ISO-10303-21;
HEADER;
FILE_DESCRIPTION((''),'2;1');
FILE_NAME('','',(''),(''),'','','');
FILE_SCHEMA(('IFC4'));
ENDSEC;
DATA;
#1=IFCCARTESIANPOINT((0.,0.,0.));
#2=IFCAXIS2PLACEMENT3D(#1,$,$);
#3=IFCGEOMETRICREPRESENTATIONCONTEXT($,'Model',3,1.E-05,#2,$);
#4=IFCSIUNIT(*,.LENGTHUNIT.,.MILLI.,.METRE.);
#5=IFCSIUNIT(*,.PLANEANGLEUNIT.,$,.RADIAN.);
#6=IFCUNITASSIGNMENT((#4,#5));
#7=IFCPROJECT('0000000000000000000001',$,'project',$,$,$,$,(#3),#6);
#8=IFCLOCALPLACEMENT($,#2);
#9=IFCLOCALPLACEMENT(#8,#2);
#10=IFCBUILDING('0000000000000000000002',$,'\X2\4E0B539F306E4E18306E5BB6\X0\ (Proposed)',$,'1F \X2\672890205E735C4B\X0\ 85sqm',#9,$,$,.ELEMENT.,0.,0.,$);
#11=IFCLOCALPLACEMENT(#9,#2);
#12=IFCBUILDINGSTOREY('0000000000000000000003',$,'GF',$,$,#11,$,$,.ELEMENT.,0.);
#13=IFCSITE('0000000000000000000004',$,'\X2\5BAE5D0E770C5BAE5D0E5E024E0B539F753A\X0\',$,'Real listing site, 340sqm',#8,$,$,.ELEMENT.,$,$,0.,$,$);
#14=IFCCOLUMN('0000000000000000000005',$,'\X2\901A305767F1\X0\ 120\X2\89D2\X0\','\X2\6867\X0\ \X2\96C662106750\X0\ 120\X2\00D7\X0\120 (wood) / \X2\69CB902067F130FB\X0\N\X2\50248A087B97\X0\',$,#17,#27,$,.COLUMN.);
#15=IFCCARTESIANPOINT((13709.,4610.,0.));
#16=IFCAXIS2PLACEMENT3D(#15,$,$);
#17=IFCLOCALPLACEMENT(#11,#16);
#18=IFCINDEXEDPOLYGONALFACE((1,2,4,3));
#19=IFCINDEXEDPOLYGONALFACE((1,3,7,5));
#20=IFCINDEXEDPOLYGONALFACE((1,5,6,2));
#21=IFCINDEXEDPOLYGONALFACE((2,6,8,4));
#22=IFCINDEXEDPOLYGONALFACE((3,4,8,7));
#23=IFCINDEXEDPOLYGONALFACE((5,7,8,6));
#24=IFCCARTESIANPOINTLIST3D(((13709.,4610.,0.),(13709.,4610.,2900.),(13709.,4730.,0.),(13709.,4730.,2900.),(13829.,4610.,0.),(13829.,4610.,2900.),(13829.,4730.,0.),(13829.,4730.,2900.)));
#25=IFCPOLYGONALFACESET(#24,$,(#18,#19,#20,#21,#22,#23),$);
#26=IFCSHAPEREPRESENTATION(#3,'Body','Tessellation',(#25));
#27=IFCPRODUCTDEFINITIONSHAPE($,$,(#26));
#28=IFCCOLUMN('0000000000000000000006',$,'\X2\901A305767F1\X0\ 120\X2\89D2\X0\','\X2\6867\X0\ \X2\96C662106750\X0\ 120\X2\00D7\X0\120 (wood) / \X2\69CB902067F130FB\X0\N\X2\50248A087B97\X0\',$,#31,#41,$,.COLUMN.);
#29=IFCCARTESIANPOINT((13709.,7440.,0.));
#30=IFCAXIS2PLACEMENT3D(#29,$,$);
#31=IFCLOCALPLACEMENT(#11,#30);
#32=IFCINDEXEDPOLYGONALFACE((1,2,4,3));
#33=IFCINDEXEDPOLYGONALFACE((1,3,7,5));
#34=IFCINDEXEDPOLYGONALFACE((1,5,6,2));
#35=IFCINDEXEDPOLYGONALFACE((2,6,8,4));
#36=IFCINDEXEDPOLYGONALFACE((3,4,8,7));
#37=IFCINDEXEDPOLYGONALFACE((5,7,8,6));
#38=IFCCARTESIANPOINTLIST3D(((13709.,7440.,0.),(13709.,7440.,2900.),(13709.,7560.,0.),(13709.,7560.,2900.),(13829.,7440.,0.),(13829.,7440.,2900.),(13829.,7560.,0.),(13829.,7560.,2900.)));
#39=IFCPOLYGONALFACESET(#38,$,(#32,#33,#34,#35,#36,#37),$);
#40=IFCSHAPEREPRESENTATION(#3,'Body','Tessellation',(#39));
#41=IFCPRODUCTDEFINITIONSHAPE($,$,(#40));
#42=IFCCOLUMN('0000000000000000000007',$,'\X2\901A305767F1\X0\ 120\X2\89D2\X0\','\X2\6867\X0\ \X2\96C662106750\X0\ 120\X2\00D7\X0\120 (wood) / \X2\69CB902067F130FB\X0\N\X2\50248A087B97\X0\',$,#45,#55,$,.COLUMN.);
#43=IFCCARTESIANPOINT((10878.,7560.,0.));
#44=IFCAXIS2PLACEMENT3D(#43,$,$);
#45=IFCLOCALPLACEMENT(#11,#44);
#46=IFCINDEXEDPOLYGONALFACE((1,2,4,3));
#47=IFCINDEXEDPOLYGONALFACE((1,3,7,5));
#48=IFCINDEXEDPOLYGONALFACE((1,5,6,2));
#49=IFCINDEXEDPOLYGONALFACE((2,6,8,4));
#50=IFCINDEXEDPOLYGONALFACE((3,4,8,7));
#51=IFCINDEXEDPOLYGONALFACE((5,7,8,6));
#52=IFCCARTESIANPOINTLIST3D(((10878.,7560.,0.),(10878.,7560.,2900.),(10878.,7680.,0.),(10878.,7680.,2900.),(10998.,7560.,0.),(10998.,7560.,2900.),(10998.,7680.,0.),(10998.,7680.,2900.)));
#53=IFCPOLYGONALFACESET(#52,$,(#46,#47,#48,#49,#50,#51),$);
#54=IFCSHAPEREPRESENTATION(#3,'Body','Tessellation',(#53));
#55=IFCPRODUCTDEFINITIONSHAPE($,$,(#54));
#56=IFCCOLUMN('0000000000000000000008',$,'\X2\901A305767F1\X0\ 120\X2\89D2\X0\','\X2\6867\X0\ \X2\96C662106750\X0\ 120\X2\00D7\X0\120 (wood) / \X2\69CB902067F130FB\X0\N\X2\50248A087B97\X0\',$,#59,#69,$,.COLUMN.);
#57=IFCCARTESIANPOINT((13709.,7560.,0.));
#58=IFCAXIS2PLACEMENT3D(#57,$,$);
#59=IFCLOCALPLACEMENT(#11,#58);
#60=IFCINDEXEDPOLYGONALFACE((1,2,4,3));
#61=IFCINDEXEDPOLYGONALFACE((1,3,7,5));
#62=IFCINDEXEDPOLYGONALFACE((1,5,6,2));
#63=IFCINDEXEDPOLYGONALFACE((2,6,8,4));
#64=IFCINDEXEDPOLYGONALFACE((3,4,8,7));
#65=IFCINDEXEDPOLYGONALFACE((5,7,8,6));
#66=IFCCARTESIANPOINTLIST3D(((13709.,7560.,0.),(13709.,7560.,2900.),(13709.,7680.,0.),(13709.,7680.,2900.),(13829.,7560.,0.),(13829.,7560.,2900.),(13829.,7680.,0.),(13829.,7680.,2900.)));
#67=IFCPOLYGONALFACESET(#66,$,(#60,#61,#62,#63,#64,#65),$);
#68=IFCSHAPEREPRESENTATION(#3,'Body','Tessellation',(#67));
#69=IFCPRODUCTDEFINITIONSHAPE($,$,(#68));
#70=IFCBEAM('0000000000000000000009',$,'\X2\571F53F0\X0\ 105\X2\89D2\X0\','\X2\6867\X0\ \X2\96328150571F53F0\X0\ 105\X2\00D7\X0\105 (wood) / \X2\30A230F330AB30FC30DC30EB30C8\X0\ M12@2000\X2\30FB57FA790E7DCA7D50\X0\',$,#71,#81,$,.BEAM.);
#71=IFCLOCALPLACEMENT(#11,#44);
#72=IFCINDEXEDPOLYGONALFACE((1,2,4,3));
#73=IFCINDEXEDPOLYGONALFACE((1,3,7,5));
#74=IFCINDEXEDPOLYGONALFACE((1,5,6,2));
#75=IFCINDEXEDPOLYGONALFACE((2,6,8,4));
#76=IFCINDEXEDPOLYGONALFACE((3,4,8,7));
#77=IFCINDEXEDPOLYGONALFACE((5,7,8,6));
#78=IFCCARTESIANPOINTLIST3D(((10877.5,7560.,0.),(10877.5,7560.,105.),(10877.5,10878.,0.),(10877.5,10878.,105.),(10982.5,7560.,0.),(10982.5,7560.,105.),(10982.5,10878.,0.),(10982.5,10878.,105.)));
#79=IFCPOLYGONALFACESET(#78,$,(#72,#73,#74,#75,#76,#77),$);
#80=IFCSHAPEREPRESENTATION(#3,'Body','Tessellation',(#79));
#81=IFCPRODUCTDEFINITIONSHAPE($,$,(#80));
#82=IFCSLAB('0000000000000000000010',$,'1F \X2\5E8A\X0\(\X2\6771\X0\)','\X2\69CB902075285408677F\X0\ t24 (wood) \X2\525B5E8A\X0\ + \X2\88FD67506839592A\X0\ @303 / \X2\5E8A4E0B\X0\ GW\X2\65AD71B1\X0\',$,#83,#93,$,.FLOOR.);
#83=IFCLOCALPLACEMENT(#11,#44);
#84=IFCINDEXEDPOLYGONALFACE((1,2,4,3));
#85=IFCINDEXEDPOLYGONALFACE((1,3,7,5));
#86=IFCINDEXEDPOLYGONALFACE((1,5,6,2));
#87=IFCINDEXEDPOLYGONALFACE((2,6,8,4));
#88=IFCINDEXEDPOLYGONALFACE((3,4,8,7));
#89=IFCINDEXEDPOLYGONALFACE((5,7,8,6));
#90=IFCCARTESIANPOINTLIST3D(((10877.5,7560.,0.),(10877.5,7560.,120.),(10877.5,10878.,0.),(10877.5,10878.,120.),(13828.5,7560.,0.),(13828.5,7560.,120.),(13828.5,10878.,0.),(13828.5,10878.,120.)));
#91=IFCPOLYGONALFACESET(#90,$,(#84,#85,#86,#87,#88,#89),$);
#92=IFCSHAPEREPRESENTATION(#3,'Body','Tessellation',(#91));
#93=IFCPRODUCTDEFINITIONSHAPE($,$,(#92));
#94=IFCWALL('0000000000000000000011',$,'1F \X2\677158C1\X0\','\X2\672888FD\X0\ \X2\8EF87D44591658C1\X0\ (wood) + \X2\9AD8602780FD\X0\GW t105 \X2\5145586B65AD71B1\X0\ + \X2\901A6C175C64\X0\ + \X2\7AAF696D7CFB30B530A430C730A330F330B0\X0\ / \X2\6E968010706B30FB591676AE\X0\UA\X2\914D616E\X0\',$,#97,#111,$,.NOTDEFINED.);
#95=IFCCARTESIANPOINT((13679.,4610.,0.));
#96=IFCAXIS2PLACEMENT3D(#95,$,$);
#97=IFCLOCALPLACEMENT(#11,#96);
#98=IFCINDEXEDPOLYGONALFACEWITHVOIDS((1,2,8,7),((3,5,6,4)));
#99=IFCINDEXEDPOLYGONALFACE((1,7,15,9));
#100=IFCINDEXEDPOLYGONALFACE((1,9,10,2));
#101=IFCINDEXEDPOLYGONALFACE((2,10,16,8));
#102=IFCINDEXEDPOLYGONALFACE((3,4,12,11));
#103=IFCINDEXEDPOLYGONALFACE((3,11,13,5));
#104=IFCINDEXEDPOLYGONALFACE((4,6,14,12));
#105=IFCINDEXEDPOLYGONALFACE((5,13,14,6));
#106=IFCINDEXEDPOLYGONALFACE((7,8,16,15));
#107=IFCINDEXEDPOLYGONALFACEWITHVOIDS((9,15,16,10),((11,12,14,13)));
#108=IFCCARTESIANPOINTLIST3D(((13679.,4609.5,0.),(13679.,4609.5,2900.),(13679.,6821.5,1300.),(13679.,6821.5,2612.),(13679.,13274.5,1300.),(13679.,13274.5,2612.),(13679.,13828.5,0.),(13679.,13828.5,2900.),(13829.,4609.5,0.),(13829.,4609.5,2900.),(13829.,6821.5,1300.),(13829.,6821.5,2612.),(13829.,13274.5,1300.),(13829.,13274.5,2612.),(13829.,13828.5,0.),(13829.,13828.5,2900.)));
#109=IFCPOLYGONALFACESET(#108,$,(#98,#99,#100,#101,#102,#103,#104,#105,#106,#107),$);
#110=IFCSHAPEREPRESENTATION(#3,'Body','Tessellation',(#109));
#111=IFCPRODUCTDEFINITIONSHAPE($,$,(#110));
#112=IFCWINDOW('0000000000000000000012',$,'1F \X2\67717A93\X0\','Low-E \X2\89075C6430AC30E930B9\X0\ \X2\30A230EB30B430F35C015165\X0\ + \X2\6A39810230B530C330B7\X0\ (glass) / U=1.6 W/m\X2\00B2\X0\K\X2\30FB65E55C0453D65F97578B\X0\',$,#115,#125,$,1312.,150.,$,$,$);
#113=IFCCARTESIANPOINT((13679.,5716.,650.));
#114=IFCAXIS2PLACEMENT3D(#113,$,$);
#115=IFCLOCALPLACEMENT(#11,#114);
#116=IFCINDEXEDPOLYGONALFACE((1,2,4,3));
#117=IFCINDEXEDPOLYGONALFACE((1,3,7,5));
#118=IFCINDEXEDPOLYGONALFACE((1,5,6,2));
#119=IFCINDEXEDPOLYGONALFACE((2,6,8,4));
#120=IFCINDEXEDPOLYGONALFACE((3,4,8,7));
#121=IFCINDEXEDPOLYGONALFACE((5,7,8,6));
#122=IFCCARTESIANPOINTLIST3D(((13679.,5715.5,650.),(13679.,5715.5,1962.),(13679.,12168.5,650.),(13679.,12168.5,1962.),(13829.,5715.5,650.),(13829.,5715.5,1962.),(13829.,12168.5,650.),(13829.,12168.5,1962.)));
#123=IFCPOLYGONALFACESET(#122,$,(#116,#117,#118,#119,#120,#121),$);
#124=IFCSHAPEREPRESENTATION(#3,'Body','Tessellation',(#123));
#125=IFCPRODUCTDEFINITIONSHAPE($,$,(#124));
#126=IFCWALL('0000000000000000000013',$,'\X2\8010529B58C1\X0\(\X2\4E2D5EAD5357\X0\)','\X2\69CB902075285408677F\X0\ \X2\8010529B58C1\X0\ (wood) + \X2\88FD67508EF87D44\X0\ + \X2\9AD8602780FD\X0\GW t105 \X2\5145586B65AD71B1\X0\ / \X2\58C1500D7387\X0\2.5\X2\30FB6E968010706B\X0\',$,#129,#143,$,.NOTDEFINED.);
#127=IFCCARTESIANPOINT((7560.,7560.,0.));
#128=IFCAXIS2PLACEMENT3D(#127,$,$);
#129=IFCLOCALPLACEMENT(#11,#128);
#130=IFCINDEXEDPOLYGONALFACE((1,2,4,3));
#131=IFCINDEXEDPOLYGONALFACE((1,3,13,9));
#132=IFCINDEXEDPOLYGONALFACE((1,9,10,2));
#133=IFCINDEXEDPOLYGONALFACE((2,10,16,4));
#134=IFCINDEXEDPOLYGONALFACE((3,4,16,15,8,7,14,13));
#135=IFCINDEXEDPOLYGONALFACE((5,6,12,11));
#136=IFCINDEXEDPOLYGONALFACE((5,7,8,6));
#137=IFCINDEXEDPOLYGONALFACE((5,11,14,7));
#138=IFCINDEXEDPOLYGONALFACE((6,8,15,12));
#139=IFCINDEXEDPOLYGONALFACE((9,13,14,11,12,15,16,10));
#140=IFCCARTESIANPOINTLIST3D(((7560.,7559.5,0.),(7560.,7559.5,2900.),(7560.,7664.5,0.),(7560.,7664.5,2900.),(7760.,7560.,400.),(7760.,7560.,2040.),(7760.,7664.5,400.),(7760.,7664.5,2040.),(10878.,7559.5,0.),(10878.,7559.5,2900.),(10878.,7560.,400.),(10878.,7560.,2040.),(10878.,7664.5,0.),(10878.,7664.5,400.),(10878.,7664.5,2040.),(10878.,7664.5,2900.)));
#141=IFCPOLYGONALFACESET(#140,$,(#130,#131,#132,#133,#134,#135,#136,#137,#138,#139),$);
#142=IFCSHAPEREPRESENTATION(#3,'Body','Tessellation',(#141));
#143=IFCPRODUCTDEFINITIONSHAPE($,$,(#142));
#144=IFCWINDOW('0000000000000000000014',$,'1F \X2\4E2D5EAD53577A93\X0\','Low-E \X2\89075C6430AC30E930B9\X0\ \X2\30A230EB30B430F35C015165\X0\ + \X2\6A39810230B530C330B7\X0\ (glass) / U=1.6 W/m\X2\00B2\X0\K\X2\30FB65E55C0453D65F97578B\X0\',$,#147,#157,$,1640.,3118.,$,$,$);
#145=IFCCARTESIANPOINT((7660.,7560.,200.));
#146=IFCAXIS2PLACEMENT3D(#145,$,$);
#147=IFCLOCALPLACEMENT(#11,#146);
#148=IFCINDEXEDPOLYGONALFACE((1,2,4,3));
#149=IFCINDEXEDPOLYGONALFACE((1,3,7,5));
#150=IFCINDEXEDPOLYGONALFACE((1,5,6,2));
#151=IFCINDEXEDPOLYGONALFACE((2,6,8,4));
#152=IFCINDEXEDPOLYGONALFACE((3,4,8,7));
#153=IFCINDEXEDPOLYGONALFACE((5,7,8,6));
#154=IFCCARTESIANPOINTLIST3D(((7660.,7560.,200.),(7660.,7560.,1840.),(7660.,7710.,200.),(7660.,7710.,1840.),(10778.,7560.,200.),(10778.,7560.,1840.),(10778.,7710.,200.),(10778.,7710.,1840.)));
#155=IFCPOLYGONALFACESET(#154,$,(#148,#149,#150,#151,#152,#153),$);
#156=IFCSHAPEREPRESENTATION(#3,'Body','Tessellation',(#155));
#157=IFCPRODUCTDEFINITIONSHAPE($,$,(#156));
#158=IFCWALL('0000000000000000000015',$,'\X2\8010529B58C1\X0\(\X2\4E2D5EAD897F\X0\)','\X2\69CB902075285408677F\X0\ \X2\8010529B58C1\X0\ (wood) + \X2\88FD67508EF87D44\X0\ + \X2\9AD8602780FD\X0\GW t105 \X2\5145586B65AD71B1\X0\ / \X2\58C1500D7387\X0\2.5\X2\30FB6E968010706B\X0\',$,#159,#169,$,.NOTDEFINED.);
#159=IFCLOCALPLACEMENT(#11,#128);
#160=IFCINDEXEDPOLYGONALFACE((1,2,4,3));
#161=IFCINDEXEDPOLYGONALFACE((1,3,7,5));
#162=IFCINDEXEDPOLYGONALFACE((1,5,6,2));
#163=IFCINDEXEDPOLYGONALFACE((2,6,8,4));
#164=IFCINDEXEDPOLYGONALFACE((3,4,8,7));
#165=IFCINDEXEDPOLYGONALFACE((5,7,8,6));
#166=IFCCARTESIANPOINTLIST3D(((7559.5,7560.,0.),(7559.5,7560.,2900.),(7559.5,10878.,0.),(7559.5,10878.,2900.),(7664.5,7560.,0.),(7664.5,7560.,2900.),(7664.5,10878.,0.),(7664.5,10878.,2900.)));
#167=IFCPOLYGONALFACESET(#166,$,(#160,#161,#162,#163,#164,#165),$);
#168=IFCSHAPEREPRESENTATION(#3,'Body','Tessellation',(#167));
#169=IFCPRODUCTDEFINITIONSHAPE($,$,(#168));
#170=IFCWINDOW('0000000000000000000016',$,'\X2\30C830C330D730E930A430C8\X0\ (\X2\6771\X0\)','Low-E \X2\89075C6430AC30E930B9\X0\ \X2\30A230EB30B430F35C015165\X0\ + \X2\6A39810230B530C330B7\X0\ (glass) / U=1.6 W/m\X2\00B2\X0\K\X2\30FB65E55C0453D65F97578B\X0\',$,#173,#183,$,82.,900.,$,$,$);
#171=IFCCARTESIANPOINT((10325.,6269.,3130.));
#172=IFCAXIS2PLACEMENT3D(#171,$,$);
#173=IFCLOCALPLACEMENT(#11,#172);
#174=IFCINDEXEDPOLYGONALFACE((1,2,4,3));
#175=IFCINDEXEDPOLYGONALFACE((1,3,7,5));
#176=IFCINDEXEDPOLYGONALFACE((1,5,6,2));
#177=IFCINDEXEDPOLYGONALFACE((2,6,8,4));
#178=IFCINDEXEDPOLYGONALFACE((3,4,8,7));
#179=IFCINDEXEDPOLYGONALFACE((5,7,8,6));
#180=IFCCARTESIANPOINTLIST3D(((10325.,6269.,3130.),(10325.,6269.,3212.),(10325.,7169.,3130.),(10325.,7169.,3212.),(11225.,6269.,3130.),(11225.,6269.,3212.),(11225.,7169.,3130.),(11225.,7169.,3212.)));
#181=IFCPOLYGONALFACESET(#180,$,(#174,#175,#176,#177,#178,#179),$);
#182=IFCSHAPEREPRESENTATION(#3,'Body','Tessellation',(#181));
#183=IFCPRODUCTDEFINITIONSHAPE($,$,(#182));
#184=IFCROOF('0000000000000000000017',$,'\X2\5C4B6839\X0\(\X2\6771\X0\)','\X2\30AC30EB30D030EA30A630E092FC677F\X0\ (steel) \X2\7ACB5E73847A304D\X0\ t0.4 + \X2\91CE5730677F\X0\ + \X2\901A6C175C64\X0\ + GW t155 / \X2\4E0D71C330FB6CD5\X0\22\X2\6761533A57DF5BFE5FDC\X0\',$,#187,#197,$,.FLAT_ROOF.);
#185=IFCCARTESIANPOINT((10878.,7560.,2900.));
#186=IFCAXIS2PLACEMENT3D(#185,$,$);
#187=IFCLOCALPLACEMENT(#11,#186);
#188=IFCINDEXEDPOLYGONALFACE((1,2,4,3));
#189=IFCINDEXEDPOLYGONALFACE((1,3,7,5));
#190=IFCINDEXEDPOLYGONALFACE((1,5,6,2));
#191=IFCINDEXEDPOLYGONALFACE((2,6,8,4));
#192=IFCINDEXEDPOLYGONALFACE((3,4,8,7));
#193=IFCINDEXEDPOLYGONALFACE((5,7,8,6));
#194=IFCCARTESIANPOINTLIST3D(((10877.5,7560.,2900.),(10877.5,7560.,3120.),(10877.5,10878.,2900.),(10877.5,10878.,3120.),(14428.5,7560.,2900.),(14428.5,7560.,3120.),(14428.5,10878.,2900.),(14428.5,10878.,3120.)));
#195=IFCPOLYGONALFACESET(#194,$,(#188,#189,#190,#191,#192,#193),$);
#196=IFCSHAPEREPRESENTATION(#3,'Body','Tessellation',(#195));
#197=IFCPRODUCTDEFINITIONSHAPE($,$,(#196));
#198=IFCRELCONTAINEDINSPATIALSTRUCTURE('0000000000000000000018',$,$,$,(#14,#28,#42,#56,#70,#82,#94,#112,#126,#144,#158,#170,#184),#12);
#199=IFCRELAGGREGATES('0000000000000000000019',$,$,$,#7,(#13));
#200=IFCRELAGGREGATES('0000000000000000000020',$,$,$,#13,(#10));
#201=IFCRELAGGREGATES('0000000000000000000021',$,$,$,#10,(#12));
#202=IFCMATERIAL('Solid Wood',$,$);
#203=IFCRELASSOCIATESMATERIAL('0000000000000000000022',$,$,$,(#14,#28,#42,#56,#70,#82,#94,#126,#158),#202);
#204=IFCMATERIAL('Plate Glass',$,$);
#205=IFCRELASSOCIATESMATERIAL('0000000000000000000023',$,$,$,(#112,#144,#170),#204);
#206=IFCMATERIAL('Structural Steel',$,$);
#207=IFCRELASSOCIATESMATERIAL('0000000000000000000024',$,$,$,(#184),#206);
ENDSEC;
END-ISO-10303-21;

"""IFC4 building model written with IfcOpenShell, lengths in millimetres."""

from ifc_helpers import new_model, si_unit, frame, frame_2d, origin, place, context, project, spatial, rectangle, extrude, material, element, fill, save


model = new_model("IFC4")

# Units and contexts
model_context = context("Model", 3, precision=1e-05, world=origin())
ifc_project = project(units=[si_unit("LENGTHUNIT", "METRE", prefix="MILLI"), si_unit("PLANEANGLEUNIT", "RADIAN")], contexts=[model_context])

# Site, building, storey
site_placement = place(None, origin())
site = spatial("IfcSite", under=ifc_project, at=site_placement, Name="宮崎県宮崎市下原町", ObjectType="Real listing site, 340sqm", CompositionType="ELEMENT", RefElevation=0.0)
building_placement = place(site_placement, origin())
building = spatial("IfcBuilding", under=site, at=building_placement, Name="下原の丘の家 (Proposed)", ObjectType="1F 木造平屋 85sqm", CompositionType="ELEMENT", ElevationOfRefHeight=0.0, ElevationOfTerrain=0.0)
storey_placement = place(building_placement, origin())
storey = spatial("IfcBuildingStorey", under=building, at=storey_placement, Name="GF", CompositionType="ELEMENT", Elevation=0.0)

# Columns
ifc_material_1 = material(Name="Solid Wood")
column_1_placement = place(storey_placement, frame((13709.0, 4610.0, 0.0)))
element("IfcColumn", 1, at=column_1_placement, inside=storey, material=ifc_material_1, Name="通し柱 120角", Description="桧 集成材 120×120 (wood) / 構造柱・N値計算", PredefinedType="COLUMN", context=model_context, shape_type="SweptSolid", body=[
    extrude(rectangle(XDim=120.0, YDim=120.0, at=frame_2d((60.0, 60.0))), frame((13709.0, 4610.0, 0.0)), (0.0, 0.0, 1.0), 2900.0),
])
column_2_placement = place(storey_placement, frame((13709.0, 7440.0, 0.0)))
element("IfcColumn", 2, at=column_2_placement, inside=storey, material=ifc_material_1, Name="通し柱 120角", Description="桧 集成材 120×120 (wood) / 構造柱・N値計算", PredefinedType="COLUMN", context=model_context, shape_type="SweptSolid", body=[
    extrude(rectangle(XDim=120.0, YDim=120.0, at=frame_2d((60.0, 60.0))), frame((13709.0, 7440.0, 0.0)), (0.0, 0.0, 1.0), 2900.0),
])
column_3_placement = place(storey_placement, frame((10878.0, 7560.0, 0.0)))
element("IfcColumn", 3, at=column_3_placement, inside=storey, material=ifc_material_1, Name="通し柱 120角", Description="桧 集成材 120×120 (wood) / 構造柱・N値計算", PredefinedType="COLUMN", context=model_context, shape_type="SweptSolid", body=[
    extrude(rectangle(XDim=120.0, YDim=120.0, at=frame_2d((60.0, 60.0))), frame((10878.0, 7560.0, 0.0)), (0.0, 0.0, 1.0), 2900.0),
])
column_4_placement = place(storey_placement, frame((13709.0, 7560.0, 0.0)))
element("IfcColumn", 4, at=column_4_placement, inside=storey, material=ifc_material_1, Name="通し柱 120角", Description="桧 集成材 120×120 (wood) / 構造柱・N値計算", PredefinedType="COLUMN", context=model_context, shape_type="SweptSolid", body=[
    extrude(rectangle(XDim=120.0, YDim=120.0, at=frame_2d((60.0, 60.0))), frame((13709.0, 7560.0, 0.0)), (0.0, 0.0, 1.0), 2900.0),
])

# Beam
beam_1_placement = place(storey_placement, frame((10878.0, 7560.0, 0.0)))
element("IfcBeam", 5, at=beam_1_placement, inside=storey, material=ifc_material_1, Name="土台 105角", Description="桧 防腐土台 105×105 (wood) / アンカーボルト M12@2000・基礎緊結", PredefinedType="BEAM", context=model_context, shape_type="SweptSolid", body=[
    extrude(rectangle(XDim=105.0, YDim=3318.0, at=frame_2d((52.0, 1659.0))), frame((10878.0, 7560.0, 0.0)), (0.0, 0.0, 1.0), 105.0),
])

# Slab
slab_placement = place(storey_placement, frame((10878.0, 7560.0, 0.0)))
element("IfcSlab", 6, at=slab_placement, inside=storey, material=ifc_material_1, Name="1F 床(東)", Description="構造用合板 t24 (wood) 剛床 + 製材根太 @303 / 床下 GW断熱", PredefinedType="FLOOR", context=model_context, shape_type="SweptSolid", body=[
    extrude(rectangle(XDim=2951.0, YDim=3318.0, at=frame_2d((1475.0, 1659.0))), frame((10878.0, 7560.0, 0.0)), (0.0, 0.0, 1.0), 120.0),
])

# Walls, openings, windows
wall_1_placement = place(storey_placement, frame((13679.0, 4610.0, 0.0)))
wall_1 = element("IfcWall", 7, at=wall_1_placement, inside=storey, material=ifc_material_1, Name="1F 東壁", Description="木製 軸組外壁 (wood) + 高性能GW t105 充填断熱 + 通気層 + 窯業系サイディング / 準耐火・外皮UA配慮", PredefinedType="NOTDEFINED", context=model_context, shape_type="SweptSolid", body=[
    extrude(rectangle(XDim=150.0, YDim=9219.0, at=frame_2d((75.0, 4609.0))), frame((13679.0, 4610.0, 0.0)), (0.0, 0.0, 1.0), 2900.0),
])
opening_1_placement = place(storey_placement, frame((13679.0, 5716.0, 650.0)))
opening_1 = element("IfcOpeningElement", 8, at=opening_1_placement, cuts=wall_1, PredefinedType="NOTDEFINED", context=model_context, shape_type="SweptSolid", body=[
    extrude(rectangle(XDim=150.0, YDim=6453.0, at=frame_2d((75.0, 3226.0))), frame((13679.0, 5716.0, 650.0)), (0.0, 0.0, 1.0), 1312.0),
])
ifc_material_2 = material(Name="Plate Glass")
window_1_placement = place(storey_placement, frame((13679.0, 5716.0, 650.0)))
window_1 = element("IfcWindow", 9, at=window_1_placement, inside=storey, material=ifc_material_2, Name="1F 東窓", Description="Low-E 複層ガラス アルゴン封入 + 樹脂サッシ (glass) / U=1.6 W/m²K・日射取得型", OverallHeight=1312.0, OverallWidth=150.0, context=model_context, shape_type="SweptSolid", body=[
    extrude(rectangle(XDim=150.0, YDim=6453.0, at=frame_2d((75.0, 3226.0))), frame((13679.0, 5716.0, 650.0)), (0.0, 0.0, 1.0), 1312.0),
])
fill(opening_1, window_1)
wall_2_placement = place(storey_placement, frame((7560.0, 7560.0, 0.0)))
wall_2 = element("IfcWall", 10, at=wall_2_placement, inside=storey, material=ifc_material_1, Name="耐力壁(中庭南)", Description="構造用合板 耐力壁 (wood) + 製材軸組 + 高性能GW t105 充填断熱 / 壁倍率2.5・準耐火", PredefinedType="NOTDEFINED", context=model_context, shape_type="SweptSolid", body=[
    extrude(rectangle(XDim=3318.0, YDim=105.0, at=frame_2d((1659.0, 52.0))), frame((7560.0, 7560.0, 0.0)), (0.0, 0.0, 1.0), 2900.0),
])
opening_2_placement = place(storey_placement, frame((7660.0, 7560.0, 200.0)))
opening_2 = element("IfcOpeningElement", 11, at=opening_2_placement, cuts=wall_2, PredefinedType="NOTDEFINED", context=model_context, shape_type="SweptSolid", body=[
    extrude(rectangle(XDim=3118.0, YDim=150.0, at=frame_2d((1559.0, 75.0))), frame((7660.0, 7560.0, 200.0)), (0.0, 0.0, 1.0), 1640.0),
])
window_2_placement = place(storey_placement, frame((7660.0, 7560.0, 200.0)))
window_2 = element("IfcWindow", 12, at=window_2_placement, inside=storey, material=ifc_material_2, Name="1F 中庭南窓", Description="Low-E 複層ガラス アルゴン封入 + 樹脂サッシ (glass) / U=1.6 W/m²K・日射取得型", OverallHeight=1640.0, OverallWidth=3118.0, context=model_context, shape_type="SweptSolid", body=[
    extrude(rectangle(XDim=3118.0, YDim=150.0, at=frame_2d((1559.0, 75.0))), frame((7660.0, 7560.0, 200.0)), (0.0, 0.0, 1.0), 1640.0),
])
fill(opening_2, window_2)

# Wall
wall_3_placement = place(storey_placement, frame((7560.0, 7560.0, 0.0)))
element("IfcWall", 13, at=wall_3_placement, inside=storey, material=ifc_material_1, Name="耐力壁(中庭西)", Description="構造用合板 耐力壁 (wood) + 製材軸組 + 高性能GW t105 充填断熱 / 壁倍率2.5・準耐火", PredefinedType="NOTDEFINED", context=model_context, shape_type="SweptSolid", body=[
    extrude(rectangle(XDim=105.0, YDim=3318.0, at=frame_2d((52.0, 1659.0))), frame((7560.0, 7560.0, 0.0)), (0.0, 0.0, 1.0), 2900.0),
])

# Window
window_3_placement = place(storey_placement, frame((10325.0, 6269.0, 3130.0)))
element("IfcWindow", 14, at=window_3_placement, inside=storey, material=ifc_material_2, Name="トップライト (東)", Description="Low-E 複層ガラス アルゴン封入 + 樹脂サッシ (glass) / U=1.6 W/m²K・日射取得型", OverallHeight=82.0, OverallWidth=900.0, context=model_context, shape_type="SweptSolid", body=[
    extrude(rectangle(XDim=900.0, YDim=900.0, at=frame_2d((450.0, 450.0))), frame((10325.0, 6269.0, 3130.0)), (0.0, 0.0, 1.0), 82.0),
])

# Roof
ifc_material_3 = material(Name="Structural Steel")
roof_placement = place(storey_placement, frame((10878.0, 7560.0, 2900.0)))
element("IfcRoof", 15, at=roof_placement, inside=storey, material=ifc_material_3, Name="屋根(東)", Description="ガルバリウム鋼板 (steel) 立平葺き t0.4 + 野地板 + 通気層 + GW t155 / 不燃・法22条区域対応", PredefinedType="FLAT_ROOF", context=model_context, shape_type="SweptSolid", body=[
    extrude(rectangle(XDim=3551.0, YDim=3318.0, at=frame_2d((1775.0, 1659.0))), frame((10878.0, 7560.0, 2900.0)), (0.0, 0.0, 1.0), 220.0),
])

save(model, "model.ifc")
